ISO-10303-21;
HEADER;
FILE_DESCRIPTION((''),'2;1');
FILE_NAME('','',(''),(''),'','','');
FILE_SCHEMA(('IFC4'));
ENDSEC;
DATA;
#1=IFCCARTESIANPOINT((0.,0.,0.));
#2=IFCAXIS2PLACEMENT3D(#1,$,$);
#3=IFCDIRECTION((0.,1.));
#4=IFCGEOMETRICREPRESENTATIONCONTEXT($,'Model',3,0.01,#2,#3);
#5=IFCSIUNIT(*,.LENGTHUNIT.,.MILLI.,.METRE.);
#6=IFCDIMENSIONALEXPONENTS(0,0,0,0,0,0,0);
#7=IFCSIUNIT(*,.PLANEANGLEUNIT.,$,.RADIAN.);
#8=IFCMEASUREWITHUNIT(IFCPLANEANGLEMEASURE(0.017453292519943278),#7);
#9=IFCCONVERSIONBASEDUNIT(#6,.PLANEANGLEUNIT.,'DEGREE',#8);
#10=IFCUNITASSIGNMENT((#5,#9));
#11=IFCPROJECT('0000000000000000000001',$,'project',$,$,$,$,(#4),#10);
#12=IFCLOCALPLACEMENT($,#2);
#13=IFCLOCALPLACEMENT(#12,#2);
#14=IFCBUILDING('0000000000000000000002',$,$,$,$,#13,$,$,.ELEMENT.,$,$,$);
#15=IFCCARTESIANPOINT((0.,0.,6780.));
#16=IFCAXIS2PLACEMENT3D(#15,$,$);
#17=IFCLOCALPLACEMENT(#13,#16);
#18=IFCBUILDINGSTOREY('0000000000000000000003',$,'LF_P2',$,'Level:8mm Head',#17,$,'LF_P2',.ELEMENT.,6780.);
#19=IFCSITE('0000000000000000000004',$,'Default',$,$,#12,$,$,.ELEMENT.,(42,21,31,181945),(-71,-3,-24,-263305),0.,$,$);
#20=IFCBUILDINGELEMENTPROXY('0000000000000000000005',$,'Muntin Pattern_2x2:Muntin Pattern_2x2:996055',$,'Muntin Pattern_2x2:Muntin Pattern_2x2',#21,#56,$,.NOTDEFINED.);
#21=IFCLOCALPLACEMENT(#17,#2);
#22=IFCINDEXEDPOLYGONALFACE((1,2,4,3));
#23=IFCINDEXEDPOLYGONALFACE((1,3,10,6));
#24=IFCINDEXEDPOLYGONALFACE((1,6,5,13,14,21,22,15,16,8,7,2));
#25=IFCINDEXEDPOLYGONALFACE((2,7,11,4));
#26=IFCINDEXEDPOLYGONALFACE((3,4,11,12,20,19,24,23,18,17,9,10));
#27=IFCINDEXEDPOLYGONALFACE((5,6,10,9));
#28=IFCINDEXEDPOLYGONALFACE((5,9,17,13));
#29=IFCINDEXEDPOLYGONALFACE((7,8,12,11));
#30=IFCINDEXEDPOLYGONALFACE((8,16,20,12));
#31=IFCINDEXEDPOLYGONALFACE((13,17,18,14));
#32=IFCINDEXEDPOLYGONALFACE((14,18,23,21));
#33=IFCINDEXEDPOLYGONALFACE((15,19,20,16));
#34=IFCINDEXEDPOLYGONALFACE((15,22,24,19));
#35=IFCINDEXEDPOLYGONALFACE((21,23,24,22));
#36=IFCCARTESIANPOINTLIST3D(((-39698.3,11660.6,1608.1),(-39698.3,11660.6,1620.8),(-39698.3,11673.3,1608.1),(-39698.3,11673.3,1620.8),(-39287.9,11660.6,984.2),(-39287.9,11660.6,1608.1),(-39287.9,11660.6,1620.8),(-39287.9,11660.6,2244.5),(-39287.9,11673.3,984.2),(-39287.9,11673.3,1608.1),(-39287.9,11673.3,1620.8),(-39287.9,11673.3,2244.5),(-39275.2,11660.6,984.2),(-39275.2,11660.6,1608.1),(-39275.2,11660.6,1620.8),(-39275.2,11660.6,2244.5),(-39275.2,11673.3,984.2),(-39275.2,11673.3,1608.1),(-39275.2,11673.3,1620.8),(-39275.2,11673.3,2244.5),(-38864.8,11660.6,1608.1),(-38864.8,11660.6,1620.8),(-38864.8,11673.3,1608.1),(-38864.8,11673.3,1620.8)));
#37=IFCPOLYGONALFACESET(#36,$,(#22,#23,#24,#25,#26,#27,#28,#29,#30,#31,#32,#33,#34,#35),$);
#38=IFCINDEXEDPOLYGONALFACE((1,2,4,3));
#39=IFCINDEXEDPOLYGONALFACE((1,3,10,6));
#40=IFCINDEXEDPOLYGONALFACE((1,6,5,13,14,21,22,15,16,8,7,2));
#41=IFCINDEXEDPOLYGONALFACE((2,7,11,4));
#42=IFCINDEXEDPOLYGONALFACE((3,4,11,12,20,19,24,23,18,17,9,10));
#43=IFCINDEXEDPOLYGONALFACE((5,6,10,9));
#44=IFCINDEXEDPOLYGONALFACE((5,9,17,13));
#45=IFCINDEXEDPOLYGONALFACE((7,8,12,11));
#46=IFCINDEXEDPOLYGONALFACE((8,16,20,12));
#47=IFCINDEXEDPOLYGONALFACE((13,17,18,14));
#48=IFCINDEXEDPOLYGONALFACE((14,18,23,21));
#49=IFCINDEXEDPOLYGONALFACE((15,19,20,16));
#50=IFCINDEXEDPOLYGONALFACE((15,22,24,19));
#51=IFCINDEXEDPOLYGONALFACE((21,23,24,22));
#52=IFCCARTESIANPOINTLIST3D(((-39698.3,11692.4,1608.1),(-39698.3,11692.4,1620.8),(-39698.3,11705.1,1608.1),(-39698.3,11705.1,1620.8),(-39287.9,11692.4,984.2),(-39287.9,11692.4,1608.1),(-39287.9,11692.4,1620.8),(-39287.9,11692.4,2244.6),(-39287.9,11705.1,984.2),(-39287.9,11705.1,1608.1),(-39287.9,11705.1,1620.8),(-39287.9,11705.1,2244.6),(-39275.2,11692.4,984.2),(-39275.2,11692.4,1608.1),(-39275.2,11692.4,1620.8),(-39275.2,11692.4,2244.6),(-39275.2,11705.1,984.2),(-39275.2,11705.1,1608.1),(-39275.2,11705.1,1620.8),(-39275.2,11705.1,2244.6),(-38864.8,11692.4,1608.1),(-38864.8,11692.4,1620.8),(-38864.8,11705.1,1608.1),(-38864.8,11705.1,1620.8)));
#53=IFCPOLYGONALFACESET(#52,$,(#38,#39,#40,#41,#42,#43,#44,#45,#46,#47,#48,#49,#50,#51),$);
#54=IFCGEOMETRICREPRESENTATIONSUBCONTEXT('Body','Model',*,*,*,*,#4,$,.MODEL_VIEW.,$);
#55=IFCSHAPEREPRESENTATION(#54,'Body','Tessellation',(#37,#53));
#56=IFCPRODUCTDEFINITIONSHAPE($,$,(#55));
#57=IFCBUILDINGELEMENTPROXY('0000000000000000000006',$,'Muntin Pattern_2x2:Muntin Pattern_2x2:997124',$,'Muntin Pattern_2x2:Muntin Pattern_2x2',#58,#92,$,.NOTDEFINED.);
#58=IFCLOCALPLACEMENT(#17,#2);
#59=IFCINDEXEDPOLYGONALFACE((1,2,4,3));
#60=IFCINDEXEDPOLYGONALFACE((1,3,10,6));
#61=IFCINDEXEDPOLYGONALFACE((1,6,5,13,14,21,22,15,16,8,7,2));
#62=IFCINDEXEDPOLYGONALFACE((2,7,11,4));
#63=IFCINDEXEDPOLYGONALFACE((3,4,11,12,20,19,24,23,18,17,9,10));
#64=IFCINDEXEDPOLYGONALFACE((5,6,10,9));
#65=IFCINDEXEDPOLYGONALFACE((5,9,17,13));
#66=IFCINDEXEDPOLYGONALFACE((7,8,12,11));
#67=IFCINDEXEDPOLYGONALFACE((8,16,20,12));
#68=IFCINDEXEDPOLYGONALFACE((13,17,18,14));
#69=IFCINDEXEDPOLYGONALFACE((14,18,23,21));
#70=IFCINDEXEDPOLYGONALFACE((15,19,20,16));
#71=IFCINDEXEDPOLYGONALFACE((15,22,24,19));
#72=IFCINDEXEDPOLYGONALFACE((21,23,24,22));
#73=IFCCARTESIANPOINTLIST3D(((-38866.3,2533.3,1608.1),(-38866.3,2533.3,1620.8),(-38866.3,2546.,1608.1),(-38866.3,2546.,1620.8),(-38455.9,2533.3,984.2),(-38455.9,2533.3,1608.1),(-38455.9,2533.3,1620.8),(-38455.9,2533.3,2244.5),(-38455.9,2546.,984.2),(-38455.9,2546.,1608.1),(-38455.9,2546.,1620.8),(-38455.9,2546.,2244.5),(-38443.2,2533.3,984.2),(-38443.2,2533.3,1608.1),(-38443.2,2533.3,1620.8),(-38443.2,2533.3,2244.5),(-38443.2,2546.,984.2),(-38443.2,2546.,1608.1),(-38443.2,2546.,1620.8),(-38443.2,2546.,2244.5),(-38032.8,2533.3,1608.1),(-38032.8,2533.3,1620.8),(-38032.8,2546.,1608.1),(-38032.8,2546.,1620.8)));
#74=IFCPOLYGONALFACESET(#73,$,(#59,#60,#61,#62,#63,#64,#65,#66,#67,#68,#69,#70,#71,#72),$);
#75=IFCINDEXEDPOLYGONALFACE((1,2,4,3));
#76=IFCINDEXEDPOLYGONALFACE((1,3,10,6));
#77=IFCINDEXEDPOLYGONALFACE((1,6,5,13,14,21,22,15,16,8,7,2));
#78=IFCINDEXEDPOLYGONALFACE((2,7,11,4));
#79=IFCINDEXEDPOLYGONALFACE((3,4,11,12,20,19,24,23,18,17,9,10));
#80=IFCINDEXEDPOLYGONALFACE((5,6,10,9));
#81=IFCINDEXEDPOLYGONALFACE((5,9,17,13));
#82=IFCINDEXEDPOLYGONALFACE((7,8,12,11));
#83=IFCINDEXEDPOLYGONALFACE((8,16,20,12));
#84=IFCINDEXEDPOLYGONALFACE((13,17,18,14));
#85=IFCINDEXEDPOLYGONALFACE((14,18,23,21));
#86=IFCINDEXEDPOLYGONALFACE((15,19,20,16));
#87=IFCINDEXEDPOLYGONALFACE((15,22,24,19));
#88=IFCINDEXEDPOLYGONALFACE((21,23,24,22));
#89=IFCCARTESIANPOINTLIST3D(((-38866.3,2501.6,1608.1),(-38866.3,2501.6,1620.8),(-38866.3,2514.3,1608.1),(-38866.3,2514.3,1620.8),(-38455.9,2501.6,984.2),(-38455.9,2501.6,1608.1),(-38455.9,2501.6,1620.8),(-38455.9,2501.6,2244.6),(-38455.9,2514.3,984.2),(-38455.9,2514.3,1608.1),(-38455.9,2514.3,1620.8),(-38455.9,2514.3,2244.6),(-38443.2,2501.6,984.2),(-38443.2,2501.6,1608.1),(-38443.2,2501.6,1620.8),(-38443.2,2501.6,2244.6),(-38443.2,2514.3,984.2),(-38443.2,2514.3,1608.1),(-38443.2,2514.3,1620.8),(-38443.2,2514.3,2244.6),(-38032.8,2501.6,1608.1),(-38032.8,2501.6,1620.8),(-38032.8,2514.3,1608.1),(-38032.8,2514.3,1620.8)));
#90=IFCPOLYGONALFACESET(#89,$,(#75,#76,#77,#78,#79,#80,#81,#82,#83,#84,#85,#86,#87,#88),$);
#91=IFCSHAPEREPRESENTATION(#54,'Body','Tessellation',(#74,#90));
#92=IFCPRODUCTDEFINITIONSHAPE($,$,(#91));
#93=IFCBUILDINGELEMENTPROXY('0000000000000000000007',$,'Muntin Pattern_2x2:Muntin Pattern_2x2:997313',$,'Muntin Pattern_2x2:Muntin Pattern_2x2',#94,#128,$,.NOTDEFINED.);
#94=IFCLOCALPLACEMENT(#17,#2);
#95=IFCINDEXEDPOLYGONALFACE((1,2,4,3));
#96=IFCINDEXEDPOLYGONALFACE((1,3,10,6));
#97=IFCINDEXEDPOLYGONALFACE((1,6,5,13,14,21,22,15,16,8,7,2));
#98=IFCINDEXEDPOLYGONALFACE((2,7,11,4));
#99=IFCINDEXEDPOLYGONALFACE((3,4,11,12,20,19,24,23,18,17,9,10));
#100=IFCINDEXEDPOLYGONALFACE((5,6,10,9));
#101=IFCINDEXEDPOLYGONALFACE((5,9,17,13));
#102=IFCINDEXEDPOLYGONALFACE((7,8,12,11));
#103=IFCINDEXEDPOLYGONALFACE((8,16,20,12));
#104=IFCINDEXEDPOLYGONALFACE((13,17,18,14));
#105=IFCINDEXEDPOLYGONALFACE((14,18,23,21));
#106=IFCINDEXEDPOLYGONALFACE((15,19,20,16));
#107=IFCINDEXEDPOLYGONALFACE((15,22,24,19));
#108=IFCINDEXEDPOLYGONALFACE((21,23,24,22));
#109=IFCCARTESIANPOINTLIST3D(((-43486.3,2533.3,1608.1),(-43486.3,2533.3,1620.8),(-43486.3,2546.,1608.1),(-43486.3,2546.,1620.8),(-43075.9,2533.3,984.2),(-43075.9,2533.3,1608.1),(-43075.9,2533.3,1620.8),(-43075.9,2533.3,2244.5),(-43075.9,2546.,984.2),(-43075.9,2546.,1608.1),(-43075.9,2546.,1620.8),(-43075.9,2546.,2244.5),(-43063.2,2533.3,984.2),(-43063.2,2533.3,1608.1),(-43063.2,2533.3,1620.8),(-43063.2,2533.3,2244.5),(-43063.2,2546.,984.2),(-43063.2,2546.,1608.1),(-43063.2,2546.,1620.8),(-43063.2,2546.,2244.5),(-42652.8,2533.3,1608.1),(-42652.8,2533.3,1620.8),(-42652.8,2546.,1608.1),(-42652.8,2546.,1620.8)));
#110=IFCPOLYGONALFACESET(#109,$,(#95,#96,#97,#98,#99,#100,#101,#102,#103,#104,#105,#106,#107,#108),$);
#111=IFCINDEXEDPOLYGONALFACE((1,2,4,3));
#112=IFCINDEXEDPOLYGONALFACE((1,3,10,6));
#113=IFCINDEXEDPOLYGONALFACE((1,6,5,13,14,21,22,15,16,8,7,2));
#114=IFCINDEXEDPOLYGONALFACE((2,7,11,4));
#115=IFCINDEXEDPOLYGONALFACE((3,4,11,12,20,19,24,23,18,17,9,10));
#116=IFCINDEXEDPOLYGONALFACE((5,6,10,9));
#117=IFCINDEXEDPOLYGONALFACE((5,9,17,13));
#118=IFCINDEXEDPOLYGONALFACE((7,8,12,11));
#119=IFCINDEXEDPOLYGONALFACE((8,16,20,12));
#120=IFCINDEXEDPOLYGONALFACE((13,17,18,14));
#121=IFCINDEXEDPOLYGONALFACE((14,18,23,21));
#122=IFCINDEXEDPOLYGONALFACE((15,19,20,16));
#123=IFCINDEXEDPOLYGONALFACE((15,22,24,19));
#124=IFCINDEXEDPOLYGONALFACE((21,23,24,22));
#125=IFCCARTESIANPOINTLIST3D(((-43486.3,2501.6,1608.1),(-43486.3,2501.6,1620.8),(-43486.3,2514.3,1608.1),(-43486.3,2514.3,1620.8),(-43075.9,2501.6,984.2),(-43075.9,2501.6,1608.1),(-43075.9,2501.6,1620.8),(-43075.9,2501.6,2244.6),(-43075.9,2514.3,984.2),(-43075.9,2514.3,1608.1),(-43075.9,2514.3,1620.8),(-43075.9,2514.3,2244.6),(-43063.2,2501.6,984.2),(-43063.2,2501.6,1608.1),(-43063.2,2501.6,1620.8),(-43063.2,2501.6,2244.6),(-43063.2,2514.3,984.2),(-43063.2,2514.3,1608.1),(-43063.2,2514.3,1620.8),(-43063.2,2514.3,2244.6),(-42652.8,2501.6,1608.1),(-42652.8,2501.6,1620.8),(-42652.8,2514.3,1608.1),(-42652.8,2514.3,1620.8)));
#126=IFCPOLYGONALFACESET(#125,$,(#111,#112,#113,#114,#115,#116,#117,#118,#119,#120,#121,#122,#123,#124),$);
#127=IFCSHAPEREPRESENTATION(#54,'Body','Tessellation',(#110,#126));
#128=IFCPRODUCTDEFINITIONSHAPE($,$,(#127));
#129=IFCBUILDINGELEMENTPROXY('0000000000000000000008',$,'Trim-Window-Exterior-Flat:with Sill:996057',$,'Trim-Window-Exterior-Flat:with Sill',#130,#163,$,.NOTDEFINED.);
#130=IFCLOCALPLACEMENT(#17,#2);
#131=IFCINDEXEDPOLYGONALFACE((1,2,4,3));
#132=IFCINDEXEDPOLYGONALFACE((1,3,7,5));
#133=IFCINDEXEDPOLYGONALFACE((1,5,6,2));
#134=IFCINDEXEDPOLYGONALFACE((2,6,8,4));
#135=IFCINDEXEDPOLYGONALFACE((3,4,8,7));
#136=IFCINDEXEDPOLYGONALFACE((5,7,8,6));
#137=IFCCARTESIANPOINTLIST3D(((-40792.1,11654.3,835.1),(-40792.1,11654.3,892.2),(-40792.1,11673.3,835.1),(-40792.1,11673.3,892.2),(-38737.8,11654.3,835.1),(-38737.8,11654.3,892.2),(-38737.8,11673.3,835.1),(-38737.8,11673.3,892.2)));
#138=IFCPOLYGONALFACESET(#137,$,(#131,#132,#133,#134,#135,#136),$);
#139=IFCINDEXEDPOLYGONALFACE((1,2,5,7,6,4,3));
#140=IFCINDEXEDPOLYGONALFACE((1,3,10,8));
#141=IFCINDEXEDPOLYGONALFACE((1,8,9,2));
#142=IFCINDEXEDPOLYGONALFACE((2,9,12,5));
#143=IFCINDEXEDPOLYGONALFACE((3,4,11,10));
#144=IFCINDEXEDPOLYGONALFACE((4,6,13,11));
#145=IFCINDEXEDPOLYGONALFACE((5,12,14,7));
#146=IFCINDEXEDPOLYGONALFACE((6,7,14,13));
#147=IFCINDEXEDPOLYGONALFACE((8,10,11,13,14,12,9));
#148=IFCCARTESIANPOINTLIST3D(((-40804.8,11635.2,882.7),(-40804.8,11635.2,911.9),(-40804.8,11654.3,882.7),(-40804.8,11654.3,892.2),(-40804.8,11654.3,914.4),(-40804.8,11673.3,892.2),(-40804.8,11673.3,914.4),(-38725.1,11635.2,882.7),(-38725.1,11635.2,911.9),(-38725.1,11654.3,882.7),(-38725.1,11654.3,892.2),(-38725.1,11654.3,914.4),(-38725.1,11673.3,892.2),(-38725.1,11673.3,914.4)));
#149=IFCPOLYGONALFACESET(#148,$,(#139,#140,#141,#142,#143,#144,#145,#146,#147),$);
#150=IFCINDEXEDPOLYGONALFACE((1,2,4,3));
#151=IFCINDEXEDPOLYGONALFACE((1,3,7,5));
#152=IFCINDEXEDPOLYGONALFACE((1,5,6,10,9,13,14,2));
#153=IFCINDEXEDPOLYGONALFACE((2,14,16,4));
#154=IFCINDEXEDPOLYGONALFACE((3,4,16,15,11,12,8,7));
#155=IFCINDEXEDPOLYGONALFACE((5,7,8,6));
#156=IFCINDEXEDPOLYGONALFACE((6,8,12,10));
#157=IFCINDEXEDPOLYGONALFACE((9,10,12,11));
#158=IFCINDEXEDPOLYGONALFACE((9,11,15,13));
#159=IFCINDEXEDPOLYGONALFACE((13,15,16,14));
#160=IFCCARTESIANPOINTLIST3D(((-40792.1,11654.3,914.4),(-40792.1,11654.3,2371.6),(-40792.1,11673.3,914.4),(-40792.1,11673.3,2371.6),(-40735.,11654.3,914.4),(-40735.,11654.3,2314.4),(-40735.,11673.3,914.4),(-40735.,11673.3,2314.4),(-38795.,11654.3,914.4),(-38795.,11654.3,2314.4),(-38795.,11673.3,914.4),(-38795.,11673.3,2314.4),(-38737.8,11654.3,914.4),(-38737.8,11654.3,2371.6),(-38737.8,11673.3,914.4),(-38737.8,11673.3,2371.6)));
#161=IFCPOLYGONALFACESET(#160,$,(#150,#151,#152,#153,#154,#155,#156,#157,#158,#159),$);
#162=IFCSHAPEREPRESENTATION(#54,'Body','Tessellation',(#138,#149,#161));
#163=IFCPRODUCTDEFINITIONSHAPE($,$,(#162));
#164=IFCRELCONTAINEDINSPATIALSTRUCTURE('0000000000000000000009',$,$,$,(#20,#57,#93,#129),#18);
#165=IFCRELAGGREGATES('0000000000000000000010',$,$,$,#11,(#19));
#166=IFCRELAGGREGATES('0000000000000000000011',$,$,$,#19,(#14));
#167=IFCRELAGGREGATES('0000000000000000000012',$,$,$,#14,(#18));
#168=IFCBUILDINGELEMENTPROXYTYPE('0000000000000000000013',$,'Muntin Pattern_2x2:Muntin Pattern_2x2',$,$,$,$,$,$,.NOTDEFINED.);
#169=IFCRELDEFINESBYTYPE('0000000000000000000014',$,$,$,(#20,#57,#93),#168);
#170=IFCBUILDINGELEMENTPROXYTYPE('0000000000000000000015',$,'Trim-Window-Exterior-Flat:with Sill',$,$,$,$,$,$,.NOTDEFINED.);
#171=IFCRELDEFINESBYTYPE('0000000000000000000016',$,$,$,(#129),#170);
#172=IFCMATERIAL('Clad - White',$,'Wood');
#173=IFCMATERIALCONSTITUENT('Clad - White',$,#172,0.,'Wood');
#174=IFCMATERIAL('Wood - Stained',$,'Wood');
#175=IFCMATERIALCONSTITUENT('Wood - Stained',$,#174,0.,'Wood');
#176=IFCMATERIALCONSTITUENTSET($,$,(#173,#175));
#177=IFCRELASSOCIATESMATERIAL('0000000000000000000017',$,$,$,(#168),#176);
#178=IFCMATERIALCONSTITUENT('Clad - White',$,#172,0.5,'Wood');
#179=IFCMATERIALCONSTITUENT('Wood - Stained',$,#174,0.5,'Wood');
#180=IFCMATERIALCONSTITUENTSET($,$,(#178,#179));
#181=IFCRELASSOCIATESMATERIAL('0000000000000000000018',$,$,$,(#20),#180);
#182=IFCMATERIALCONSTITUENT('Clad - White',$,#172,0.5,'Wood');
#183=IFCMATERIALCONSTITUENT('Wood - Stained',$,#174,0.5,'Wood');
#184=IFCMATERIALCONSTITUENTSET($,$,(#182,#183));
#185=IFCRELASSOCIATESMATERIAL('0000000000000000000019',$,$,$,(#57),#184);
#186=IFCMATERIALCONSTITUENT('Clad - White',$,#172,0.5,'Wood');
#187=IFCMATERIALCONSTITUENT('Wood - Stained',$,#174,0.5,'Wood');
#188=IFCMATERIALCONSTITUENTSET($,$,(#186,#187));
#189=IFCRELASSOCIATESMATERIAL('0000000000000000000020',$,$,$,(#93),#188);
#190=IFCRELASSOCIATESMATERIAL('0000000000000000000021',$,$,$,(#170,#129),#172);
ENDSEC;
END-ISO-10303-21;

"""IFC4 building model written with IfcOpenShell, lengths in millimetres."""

from ifc_helpers import new_model, entity, si_unit, converted_unit, direction, frame, origin, place, context, subcontext, project, spatial, indexed_curve, outline, extrude, source, transform, mapped, material, constituent, constituent_set, type_object, type_shapes, element, save


model = new_model("IFC4")

# Units and contexts
model_context = context("Model", 3, precision=0.01, world=origin(), true_north=direction((0.0, 1.0)))
body_context = subcontext(model_context, "Body", "Model", "MODEL_VIEW")
ifc_project = project(units=[si_unit("LENGTHUNIT", "METRE", prefix="MILLI"), converted_unit("PLANEANGLEUNIT", "DEGREE", entity("IfcPlaneAngleMeasure", 0.017453292519943278), si_unit("PLANEANGLEUNIT", "RADIAN"), dimensions=[0, 0, 0, 0, 0, 0, 0])], contexts=[model_context])

# Site, building, storey
site_placement = place(None, origin())
site = spatial("IfcSite", under=ifc_project, at=site_placement, Name="Default", CompositionType="ELEMENT", RefLatitude=(42, 21, 31, 181945), RefLongitude=(-71, -3, -24, -263305), RefElevation=0.0)
building_placement = place(site_placement, origin())
building = spatial("IfcBuilding", under=site, at=building_placement, CompositionType="ELEMENT")
storey_placement = place(building_placement, frame((0.0, 0.0, 6780.0)))
storey = spatial("IfcBuildingStorey", under=building, at=storey_placement, Name="LF_P2", ObjectType="Level:8mm Head", LongName="LF_P2", CompositionType="ELEMENT", Elevation=6780.0)

# Building element proxies
ifc_material_1 = material(Name="Clad - White", Category="Wood")
ifc_material_2 = material(Name="Wood - Stained", Category="Wood")
ifc_constituent_1 = constituent(ifc_material_1, Name="Clad - White", Category="Wood", fraction=0.5)
ifc_constituent_2 = constituent(ifc_material_2, Name="Wood - Stained", Category="Wood", fraction=0.5)
ifc_constituent_set_1 = constituent_set(constituents=[ifc_constituent_1, ifc_constituent_2])
ifc_constituent_3 = constituent(ifc_material_1, Name="Clad - White", Category="Wood", fraction=0.0)
ifc_constituent_4 = constituent(ifc_material_2, Name="Wood - Stained", Category="Wood", fraction=0.0)
ifc_constituent_set_2 = constituent_set(constituents=[ifc_constituent_3, ifc_constituent_4])
building_element_proxy_type_1 = type_object("IfcBuildingElementProxyType", Name="Muntin Pattern_2x2:Muntin Pattern_2x2", PredefinedType="NOTDEFINED", material=ifc_constituent_set_2)
shared_shape_1 = source(origin(), body_context, "Body", "SweptSolid", [
    extrude(outline(indexed_curve([(6.4, -6.4), (630.1, -6.4), (630.1, 6.3), (6.4, 6.3), (6.4, 416.7), (-6.3, 416.7), (-6.3, 6.3), (-630.2, 6.3), (-630.2, -6.4), (-6.3, -6.4), (-6.3, -416.7), (6.4, -416.7), (6.4, -6.4)], self_intersect=False)), frame((0.0, 9.5, 630.1), z_axis=(0.0, 1.0, 0.0), x_axis=(0.0, 0.0, 1.0)), (0.0, 0.0, 1.0), 12.7),
    extrude(outline(indexed_curve([(6.4, -6.4), (630.2, -6.4), (630.2, 6.3), (6.4, 6.3), (6.4, 416.7), (-6.3, 416.7), (-6.3, 6.3), (-630.2, 6.3), (-630.2, -6.4), (-6.3, -6.4), (-6.3, -416.7), (6.4, -416.7), (6.4, -6.4)], self_intersect=False)), frame((0.0, -22.2, 630.2), z_axis=(0.0, 1.0, 0.0), x_axis=(0.0, 0.0, 1.0)), (0.0, 0.0, 1.0), 12.7),
])
type_shapes(building_element_proxy_type_1, [shared_shape_1])
proxy_1_placement = place(storey_placement, frame((-39281.6, 11682.9, 984.3), z_axis=(0.0, 0.0, 1.0), x_axis=(-1.0, 0.0, 0.0)))
element("IfcBuildingElementProxy", 1, at=proxy_1_placement, inside=storey, type_object=building_element_proxy_type_1, material=ifc_constituent_set_1, Name="Muntin Pattern_2x2:Muntin Pattern_2x2:996055", ObjectType="Muntin Pattern_2x2:Muntin Pattern_2x2", PredefinedType="NOTDEFINED", context=body_context, shape_type="MappedRepresentation", body=[
    mapped(shared_shape_1, transform((0.0, 0.0, 0.0), scale=1.0)),
])
ifc_constituent_5 = constituent(ifc_material_1, Name="Clad - White", Category="Wood", fraction=0.5)
ifc_constituent_6 = constituent(ifc_material_2, Name="Wood - Stained", Category="Wood", fraction=0.5)
ifc_constituent_set_3 = constituent_set(constituents=[ifc_constituent_5, ifc_constituent_6])
proxy_2_placement = place(storey_placement, frame((-38449.5, 2523.8, 984.3)))
element("IfcBuildingElementProxy", 2, at=proxy_2_placement, inside=storey, type_object=building_element_proxy_type_1, material=ifc_constituent_set_3, Name="Muntin Pattern_2x2:Muntin Pattern_2x2:997124", ObjectType="Muntin Pattern_2x2:Muntin Pattern_2x2", PredefinedType="NOTDEFINED", context=body_context, shape_type="MappedRepresentation", body=[
    mapped(shared_shape_1, transform((0.0, 0.0, 0.0), scale=1.0)),
])
ifc_constituent_7 = constituent(ifc_material_1, Name="Clad - White", Category="Wood", fraction=0.5)
ifc_constituent_8 = constituent(ifc_material_2, Name="Wood - Stained", Category="Wood", fraction=0.5)
ifc_constituent_set_4 = constituent_set(constituents=[ifc_constituent_7, ifc_constituent_8])
proxy_3_placement = place(storey_placement, frame((-43069.5, 2523.8, 984.3)))
element("IfcBuildingElementProxy", 3, at=proxy_3_placement, inside=storey, type_object=building_element_proxy_type_1, material=ifc_constituent_set_4, Name="Muntin Pattern_2x2:Muntin Pattern_2x2:997313", ObjectType="Muntin Pattern_2x2:Muntin Pattern_2x2", PredefinedType="NOTDEFINED", context=body_context, shape_type="MappedRepresentation", body=[
    mapped(shared_shape_1, transform((0.0, 0.0, 0.0), scale=1.0)),
])
building_element_proxy_type_2 = type_object("IfcBuildingElementProxyType", Name="Trim-Window-Exterior-Flat:with Sill", PredefinedType="NOTDEFINED", material=ifc_material_1)
shared_shape_2 = source(origin(), body_context, "Body", "SweptSolid", [
    extrude(outline(indexed_curve([(-1027.1, -28.6), (1027.1, -28.6), (1027.1, 28.6), (-1027.1, 28.6), (-1027.1, -28.6)], self_intersect=False)), frame((0.0, -1450.8, 0.0), z_axis=(0.0, 0.0, 1.0), x_axis=(-1.0, 0.0, 0.0)), (0.0, 0.0, 1.0), 19.0),
    extrude(outline(indexed_curve([(-19.0, -16.0), (0.0, -16.0), (0.0, -6.4), (19.0, -6.4), (19.0, 15.8), (0.0, 15.8), (-19.0, 13.3), (-19.0, -16.0)], self_intersect=False)), frame((-1039.8, -1415.8, 19.0), z_axis=(1.0, 0.0, 0.0), x_axis=(0.0, 0.0, -1.0)), (0.0, 0.0, 1.0), 2079.7),
    extrude(outline(indexed_curve([(-742.9, -1027.1), (714.3, -1027.1), (714.3, -970.0), (-685.7, -970.0), (-685.7, 970.0), (714.3, 970.0), (714.3, 1027.1), (-742.9, 1027.1), (-742.9, -1027.1)], self_intersect=False)), frame((0.0, -685.7, 0.0), z_axis=(0.0, 0.0, 1.0), x_axis=(0.0, -1.0, 0.0)), (0.0, 0.0, 1.0), 19.0),
])
type_shapes(building_element_proxy_type_2, [shared_shape_2])
for number, where, z_axis, x_axis, name in (
    (4, (-39765.0, 11673.3, 2314.4), (0.0, -1.0, 0.0), (1.0, 0.0, 0.0), "Trim-Window-Exterior-Flat:with Sill:996057"),
):
    element("IfcBuildingElementProxy", number, at=place(storey_placement, frame(where, z_axis=z_axis, x_axis=x_axis)), inside=storey, type_object=building_element_proxy_type_2, material=ifc_material_1, Name=name, ObjectType="Trim-Window-Exterior-Flat:with Sill", PredefinedType="NOTDEFINED", context=body_context, shape_type="MappedRepresentation", body=[
        mapped(shared_shape_2, transform((0.0, 0.0, 0.0), scale=1.0)),
    ])

save(model, "model.ifc")
